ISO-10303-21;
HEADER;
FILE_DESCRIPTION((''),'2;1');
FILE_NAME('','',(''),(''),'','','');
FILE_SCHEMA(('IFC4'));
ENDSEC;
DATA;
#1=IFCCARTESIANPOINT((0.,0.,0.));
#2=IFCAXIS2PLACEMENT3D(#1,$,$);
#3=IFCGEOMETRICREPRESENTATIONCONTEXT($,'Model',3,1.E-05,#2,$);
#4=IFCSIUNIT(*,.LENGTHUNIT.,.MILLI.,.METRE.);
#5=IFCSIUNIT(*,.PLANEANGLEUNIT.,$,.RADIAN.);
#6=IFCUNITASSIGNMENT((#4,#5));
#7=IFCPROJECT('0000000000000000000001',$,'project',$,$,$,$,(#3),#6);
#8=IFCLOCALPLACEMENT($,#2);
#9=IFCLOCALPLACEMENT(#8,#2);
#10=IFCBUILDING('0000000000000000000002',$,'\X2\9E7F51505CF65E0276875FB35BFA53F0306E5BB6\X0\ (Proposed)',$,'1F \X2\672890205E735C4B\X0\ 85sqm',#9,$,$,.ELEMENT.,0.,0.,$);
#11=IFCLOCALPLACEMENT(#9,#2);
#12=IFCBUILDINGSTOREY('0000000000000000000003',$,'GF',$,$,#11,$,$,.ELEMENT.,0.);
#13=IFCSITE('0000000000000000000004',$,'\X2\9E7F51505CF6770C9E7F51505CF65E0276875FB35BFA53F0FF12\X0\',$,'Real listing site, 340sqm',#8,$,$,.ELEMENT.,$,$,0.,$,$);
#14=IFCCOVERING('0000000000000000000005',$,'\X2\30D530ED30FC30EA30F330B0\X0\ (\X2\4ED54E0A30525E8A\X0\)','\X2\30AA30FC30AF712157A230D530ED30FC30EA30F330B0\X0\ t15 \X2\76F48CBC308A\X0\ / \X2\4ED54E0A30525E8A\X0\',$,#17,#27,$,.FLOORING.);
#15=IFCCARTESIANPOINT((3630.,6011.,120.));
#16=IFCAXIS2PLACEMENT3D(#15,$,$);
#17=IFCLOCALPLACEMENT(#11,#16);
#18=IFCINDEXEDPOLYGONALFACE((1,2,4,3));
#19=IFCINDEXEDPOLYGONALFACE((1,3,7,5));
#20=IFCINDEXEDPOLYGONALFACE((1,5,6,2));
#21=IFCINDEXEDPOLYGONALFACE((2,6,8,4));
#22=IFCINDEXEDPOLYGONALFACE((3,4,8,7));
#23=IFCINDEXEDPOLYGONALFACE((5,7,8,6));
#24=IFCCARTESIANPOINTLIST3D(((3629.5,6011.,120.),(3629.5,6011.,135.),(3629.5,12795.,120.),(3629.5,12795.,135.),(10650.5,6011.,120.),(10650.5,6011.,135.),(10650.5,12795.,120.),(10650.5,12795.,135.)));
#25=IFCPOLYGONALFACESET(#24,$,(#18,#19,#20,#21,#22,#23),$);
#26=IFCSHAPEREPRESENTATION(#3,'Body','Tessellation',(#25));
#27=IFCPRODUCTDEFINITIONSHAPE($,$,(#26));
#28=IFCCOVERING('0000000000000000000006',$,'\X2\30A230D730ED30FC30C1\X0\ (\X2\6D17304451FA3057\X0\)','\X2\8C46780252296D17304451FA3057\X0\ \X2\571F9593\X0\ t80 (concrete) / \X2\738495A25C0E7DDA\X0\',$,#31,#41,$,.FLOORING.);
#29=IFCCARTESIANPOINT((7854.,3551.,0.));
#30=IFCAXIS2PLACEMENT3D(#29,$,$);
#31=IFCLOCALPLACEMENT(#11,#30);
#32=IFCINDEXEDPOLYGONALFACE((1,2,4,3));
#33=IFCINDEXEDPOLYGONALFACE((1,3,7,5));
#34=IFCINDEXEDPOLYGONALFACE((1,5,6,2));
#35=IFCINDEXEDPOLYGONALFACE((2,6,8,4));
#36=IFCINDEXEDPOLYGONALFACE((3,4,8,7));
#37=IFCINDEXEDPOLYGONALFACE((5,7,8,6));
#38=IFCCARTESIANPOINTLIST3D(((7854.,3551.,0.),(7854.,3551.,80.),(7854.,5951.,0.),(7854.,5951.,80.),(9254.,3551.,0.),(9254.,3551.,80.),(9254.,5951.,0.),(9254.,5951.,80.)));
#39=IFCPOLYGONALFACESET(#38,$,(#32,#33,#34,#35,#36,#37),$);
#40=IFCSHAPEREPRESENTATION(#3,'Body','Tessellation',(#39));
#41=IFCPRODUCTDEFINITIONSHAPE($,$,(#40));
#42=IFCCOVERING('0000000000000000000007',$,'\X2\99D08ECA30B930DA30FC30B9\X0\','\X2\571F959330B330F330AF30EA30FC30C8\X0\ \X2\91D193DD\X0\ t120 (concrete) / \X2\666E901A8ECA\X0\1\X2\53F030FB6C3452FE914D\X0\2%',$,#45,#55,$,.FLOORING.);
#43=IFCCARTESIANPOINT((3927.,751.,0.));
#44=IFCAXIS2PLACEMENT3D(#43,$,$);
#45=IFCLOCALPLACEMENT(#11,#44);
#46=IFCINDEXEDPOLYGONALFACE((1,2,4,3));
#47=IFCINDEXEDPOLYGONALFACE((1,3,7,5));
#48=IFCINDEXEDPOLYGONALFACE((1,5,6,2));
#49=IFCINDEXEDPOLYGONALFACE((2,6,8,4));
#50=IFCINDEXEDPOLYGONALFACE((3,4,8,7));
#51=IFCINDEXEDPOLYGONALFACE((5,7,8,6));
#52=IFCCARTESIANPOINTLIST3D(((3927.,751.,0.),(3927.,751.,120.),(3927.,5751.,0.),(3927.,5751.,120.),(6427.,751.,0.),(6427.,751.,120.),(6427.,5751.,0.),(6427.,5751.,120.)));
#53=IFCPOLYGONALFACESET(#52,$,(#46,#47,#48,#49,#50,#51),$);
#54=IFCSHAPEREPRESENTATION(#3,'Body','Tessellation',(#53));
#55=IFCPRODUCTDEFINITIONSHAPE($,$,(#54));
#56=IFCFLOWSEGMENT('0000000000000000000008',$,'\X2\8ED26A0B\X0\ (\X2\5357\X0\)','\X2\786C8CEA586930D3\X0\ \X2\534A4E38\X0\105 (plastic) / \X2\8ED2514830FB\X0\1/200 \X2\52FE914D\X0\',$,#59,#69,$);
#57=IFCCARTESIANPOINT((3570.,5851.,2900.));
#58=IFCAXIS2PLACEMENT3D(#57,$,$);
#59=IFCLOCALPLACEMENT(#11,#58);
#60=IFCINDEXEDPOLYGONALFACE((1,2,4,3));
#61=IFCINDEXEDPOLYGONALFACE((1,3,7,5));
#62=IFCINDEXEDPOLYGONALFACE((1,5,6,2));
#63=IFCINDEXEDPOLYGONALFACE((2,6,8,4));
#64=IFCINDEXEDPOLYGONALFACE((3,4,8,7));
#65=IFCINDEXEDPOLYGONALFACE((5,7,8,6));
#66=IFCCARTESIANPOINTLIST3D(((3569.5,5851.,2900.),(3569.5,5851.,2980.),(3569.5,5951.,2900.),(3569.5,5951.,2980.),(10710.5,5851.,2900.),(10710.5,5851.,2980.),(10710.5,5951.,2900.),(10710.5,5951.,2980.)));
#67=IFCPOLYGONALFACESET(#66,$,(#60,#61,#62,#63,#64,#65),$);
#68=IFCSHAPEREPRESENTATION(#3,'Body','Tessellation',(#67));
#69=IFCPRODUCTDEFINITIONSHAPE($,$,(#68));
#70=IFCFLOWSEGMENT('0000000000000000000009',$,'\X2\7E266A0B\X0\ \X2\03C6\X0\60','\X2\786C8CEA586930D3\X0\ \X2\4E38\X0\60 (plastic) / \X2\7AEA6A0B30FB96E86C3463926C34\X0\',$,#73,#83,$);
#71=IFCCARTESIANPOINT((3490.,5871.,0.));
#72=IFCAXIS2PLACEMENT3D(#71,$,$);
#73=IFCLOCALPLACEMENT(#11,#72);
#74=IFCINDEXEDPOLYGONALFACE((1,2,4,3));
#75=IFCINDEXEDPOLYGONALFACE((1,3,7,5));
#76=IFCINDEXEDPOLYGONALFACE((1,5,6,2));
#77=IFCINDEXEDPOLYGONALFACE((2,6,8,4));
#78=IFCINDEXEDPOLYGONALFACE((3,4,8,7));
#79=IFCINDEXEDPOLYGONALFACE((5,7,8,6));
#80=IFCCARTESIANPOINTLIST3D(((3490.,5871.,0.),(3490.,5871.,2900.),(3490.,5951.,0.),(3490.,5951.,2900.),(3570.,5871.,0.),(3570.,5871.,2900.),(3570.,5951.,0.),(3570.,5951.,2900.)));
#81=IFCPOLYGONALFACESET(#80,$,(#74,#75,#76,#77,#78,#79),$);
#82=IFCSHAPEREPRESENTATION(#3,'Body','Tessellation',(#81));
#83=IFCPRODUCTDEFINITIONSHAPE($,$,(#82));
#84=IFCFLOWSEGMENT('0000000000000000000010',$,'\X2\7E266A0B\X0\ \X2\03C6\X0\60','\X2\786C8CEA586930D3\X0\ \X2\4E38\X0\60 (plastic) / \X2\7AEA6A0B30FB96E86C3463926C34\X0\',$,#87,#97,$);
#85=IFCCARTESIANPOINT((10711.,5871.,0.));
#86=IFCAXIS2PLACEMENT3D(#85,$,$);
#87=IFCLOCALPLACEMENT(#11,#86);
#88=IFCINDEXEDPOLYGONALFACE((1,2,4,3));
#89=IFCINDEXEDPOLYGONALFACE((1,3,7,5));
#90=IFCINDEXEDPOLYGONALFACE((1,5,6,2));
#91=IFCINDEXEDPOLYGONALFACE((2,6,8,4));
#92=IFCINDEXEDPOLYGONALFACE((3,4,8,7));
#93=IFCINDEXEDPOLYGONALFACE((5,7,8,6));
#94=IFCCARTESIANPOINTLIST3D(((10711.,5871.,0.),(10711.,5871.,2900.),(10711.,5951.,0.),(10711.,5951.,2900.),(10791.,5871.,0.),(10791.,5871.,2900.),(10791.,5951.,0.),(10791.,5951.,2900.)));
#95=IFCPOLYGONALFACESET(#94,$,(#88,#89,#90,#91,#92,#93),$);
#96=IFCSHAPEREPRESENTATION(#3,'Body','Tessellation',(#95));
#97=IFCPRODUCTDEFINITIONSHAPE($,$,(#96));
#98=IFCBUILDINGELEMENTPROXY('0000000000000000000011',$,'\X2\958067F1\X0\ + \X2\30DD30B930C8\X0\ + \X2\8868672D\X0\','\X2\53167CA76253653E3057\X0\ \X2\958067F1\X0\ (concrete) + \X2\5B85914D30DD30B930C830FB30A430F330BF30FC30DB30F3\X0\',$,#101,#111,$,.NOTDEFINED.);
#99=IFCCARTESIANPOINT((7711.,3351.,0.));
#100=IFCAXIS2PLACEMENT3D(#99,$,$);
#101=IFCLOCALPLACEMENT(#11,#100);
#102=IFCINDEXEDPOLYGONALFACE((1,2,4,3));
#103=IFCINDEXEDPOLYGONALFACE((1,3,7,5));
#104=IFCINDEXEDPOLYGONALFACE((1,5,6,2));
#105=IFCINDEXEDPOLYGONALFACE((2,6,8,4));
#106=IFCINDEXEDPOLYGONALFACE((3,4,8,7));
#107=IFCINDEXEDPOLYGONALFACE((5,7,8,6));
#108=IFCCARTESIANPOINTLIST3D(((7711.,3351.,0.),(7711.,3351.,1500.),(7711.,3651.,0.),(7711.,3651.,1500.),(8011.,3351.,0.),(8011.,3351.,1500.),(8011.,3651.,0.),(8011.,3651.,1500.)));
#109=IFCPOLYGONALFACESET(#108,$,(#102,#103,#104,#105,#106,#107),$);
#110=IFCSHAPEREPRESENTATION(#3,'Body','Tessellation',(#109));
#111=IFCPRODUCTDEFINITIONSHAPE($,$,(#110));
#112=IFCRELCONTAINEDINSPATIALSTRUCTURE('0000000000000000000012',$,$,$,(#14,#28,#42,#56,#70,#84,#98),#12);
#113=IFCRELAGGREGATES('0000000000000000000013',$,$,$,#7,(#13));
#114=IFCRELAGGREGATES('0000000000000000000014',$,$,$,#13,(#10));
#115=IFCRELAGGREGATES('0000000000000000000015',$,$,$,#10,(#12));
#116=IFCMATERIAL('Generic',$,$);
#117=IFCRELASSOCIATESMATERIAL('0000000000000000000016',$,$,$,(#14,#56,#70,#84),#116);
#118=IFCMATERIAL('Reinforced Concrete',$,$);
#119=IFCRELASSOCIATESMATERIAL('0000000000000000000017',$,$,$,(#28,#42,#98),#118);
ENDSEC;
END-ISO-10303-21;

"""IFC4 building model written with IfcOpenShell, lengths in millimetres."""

from ifc_helpers import new_model, si_unit, frame, frame_2d, origin, place, context, project, spatial, rectangle, extrude, material, element, save


model = new_model("IFC4")

# Units and contexts
model_context = context("Model", 3, precision=1e-05, world=origin())
ifc_project = project(units=[si_unit("LENGTHUNIT", "METRE", prefix="MILLI"), si_unit("PLANEANGLEUNIT", "RADIAN")], contexts=[model_context])

# Site, building, storey
site_placement = place(None, origin())
site = spatial("IfcSite", under=ifc_project, at=site_placement, Name="鹿児島県鹿児島市皇徳寺台２", ObjectType="Real listing site, 340sqm", CompositionType="ELEMENT", RefElevation=0.0)
building_placement = place(site_placement, origin())
building = spatial("IfcBuilding", under=site, at=building_placement, Name="鹿児島市皇徳寺台の家 (Proposed)", ObjectType="1F 木造平屋 85sqm", CompositionType="ELEMENT", ElevationOfRefHeight=0.0, ElevationOfTerrain=0.0)
storey_placement = place(building_placement, origin())
storey = spatial("IfcBuildingStorey", under=building, at=storey_placement, Name="GF", CompositionType="ELEMENT", Elevation=0.0)

# Shared definitions
ifc_material_1 = material(Name="Reinforced Concrete")

# Coverings
ifc_material_2 = material(Name="Generic")
covering_1_placement = place(storey_placement, frame((3630.0, 6011.0, 120.0)))
element("IfcCovering", 1, at=covering_1_placement, inside=storey, material=ifc_material_2, Name="フローリング (仕上げ床)", Description="オーク無垢フローリング t15 直貼り / 仕上げ床", PredefinedType="FLOORING", context=model_context, shape_type="SweptSolid", body=[
    extrude(rectangle(XDim=7021.0, YDim=6784.0, at=frame_2d((3510.0, 3392.0))), frame((3630.0, 6011.0, 120.0)), (0.0, 0.0, 1.0), 15.0),
])
covering_2_placement = place(storey_placement, frame((7854.0, 3551.0, 0.0)))
element("IfcCovering", 2, at=covering_2_placement, inside=storey, material=ifc_material_1, Name="アプローチ (洗い出し)", Description="豆砂利洗い出し 土間 t80 (concrete) / 玄関導線", PredefinedType="FLOORING", context=model_context, shape_type="SweptSolid", body=[
    extrude(rectangle(XDim=1400.0, YDim=2400.0, at=frame_2d((700.0, 1200.0))), frame((7854.0, 3551.0, 0.0)), (0.0, 0.0, 1.0), 80.0),
])
covering_3_placement = place(storey_placement, frame((3927.0, 751.0, 0.0)))
element("IfcCovering", 3, at=covering_3_placement, inside=storey, material=ifc_material_1, Name="駐車スペース", Description="土間コンクリート 金鏝 t120 (concrete) / 普通車1台・水勾配2%", PredefinedType="FLOORING", context=model_context, shape_type="SweptSolid", body=[
    extrude(rectangle(XDim=2500.0, YDim=5000.0, at=frame_2d((1250.0, 2500.0))), frame((3927.0, 751.0, 0.0)), (0.0, 0.0, 1.0), 120.0),
])

# Flow segments
flow_segment_1_placement = place(storey_placement, frame((3570.0, 5851.0, 2900.0)))
element("IfcFlowSegment", 4, at=flow_segment_1_placement, inside=storey, material=ifc_material_2, Name="軒樋 (南)", Description="硬質塩ビ 半丸105 (plastic) / 軒先・1/200 勾配", context=model_context, shape_type="SweptSolid", body=[
    extrude(rectangle(XDim=7141.0, YDim=100.0, at=frame_2d((3570.0, 50.0))), frame((3570.0, 5851.0, 2900.0)), (0.0, 0.0, 1.0), 80.0),
])
flow_segment_2_placement = place(storey_placement, frame((3490.0, 5871.0, 0.0)))
element("IfcFlowSegment", 5, at=flow_segment_2_placement, inside=storey, material=ifc_material_2, Name="縦樋 φ60", Description="硬質塩ビ 丸60 (plastic) / 竪樋・雨水排水", context=model_context, shape_type="SweptSolid", body=[
    extrude(rectangle(XDim=80.0, YDim=80.0, at=frame_2d((40.0, 40.0))), frame((3490.0, 5871.0, 0.0)), (0.0, 0.0, 1.0), 2900.0),
])
flow_segment_3_placement = place(storey_placement, frame((10711.0, 5871.0, 0.0)))
element("IfcFlowSegment", 6, at=flow_segment_3_placement, inside=storey, material=ifc_material_2, Name="縦樋 φ60", Description="硬質塩ビ 丸60 (plastic) / 竪樋・雨水排水", context=model_context, shape_type="SweptSolid", body=[
    extrude(rectangle(XDim=80.0, YDim=80.0, at=frame_2d((40.0, 40.0))), frame((10711.0, 5871.0, 0.0)), (0.0, 0.0, 1.0), 2900.0),
])

# Building element proxy
proxy_placement = place(storey_placement, frame((7711.0, 3351.0, 0.0)))
element("IfcBuildingElementProxy", 7, at=proxy_placement, inside=storey, material=ifc_material_1, Name="門柱 + ポスト + 表札", Description="化粧打放し 門柱 (concrete) + 宅配ポスト・インターホン", PredefinedType="NOTDEFINED", context=model_context, shape_type="SweptSolid", body=[
    extrude(rectangle(XDim=300.0, YDim=300.0, at=frame_2d((150.0, 150.0))), frame((7711.0, 3351.0, 0.0)), (0.0, 0.0, 1.0), 1500.0),
])

save(model, "model.ifc")
